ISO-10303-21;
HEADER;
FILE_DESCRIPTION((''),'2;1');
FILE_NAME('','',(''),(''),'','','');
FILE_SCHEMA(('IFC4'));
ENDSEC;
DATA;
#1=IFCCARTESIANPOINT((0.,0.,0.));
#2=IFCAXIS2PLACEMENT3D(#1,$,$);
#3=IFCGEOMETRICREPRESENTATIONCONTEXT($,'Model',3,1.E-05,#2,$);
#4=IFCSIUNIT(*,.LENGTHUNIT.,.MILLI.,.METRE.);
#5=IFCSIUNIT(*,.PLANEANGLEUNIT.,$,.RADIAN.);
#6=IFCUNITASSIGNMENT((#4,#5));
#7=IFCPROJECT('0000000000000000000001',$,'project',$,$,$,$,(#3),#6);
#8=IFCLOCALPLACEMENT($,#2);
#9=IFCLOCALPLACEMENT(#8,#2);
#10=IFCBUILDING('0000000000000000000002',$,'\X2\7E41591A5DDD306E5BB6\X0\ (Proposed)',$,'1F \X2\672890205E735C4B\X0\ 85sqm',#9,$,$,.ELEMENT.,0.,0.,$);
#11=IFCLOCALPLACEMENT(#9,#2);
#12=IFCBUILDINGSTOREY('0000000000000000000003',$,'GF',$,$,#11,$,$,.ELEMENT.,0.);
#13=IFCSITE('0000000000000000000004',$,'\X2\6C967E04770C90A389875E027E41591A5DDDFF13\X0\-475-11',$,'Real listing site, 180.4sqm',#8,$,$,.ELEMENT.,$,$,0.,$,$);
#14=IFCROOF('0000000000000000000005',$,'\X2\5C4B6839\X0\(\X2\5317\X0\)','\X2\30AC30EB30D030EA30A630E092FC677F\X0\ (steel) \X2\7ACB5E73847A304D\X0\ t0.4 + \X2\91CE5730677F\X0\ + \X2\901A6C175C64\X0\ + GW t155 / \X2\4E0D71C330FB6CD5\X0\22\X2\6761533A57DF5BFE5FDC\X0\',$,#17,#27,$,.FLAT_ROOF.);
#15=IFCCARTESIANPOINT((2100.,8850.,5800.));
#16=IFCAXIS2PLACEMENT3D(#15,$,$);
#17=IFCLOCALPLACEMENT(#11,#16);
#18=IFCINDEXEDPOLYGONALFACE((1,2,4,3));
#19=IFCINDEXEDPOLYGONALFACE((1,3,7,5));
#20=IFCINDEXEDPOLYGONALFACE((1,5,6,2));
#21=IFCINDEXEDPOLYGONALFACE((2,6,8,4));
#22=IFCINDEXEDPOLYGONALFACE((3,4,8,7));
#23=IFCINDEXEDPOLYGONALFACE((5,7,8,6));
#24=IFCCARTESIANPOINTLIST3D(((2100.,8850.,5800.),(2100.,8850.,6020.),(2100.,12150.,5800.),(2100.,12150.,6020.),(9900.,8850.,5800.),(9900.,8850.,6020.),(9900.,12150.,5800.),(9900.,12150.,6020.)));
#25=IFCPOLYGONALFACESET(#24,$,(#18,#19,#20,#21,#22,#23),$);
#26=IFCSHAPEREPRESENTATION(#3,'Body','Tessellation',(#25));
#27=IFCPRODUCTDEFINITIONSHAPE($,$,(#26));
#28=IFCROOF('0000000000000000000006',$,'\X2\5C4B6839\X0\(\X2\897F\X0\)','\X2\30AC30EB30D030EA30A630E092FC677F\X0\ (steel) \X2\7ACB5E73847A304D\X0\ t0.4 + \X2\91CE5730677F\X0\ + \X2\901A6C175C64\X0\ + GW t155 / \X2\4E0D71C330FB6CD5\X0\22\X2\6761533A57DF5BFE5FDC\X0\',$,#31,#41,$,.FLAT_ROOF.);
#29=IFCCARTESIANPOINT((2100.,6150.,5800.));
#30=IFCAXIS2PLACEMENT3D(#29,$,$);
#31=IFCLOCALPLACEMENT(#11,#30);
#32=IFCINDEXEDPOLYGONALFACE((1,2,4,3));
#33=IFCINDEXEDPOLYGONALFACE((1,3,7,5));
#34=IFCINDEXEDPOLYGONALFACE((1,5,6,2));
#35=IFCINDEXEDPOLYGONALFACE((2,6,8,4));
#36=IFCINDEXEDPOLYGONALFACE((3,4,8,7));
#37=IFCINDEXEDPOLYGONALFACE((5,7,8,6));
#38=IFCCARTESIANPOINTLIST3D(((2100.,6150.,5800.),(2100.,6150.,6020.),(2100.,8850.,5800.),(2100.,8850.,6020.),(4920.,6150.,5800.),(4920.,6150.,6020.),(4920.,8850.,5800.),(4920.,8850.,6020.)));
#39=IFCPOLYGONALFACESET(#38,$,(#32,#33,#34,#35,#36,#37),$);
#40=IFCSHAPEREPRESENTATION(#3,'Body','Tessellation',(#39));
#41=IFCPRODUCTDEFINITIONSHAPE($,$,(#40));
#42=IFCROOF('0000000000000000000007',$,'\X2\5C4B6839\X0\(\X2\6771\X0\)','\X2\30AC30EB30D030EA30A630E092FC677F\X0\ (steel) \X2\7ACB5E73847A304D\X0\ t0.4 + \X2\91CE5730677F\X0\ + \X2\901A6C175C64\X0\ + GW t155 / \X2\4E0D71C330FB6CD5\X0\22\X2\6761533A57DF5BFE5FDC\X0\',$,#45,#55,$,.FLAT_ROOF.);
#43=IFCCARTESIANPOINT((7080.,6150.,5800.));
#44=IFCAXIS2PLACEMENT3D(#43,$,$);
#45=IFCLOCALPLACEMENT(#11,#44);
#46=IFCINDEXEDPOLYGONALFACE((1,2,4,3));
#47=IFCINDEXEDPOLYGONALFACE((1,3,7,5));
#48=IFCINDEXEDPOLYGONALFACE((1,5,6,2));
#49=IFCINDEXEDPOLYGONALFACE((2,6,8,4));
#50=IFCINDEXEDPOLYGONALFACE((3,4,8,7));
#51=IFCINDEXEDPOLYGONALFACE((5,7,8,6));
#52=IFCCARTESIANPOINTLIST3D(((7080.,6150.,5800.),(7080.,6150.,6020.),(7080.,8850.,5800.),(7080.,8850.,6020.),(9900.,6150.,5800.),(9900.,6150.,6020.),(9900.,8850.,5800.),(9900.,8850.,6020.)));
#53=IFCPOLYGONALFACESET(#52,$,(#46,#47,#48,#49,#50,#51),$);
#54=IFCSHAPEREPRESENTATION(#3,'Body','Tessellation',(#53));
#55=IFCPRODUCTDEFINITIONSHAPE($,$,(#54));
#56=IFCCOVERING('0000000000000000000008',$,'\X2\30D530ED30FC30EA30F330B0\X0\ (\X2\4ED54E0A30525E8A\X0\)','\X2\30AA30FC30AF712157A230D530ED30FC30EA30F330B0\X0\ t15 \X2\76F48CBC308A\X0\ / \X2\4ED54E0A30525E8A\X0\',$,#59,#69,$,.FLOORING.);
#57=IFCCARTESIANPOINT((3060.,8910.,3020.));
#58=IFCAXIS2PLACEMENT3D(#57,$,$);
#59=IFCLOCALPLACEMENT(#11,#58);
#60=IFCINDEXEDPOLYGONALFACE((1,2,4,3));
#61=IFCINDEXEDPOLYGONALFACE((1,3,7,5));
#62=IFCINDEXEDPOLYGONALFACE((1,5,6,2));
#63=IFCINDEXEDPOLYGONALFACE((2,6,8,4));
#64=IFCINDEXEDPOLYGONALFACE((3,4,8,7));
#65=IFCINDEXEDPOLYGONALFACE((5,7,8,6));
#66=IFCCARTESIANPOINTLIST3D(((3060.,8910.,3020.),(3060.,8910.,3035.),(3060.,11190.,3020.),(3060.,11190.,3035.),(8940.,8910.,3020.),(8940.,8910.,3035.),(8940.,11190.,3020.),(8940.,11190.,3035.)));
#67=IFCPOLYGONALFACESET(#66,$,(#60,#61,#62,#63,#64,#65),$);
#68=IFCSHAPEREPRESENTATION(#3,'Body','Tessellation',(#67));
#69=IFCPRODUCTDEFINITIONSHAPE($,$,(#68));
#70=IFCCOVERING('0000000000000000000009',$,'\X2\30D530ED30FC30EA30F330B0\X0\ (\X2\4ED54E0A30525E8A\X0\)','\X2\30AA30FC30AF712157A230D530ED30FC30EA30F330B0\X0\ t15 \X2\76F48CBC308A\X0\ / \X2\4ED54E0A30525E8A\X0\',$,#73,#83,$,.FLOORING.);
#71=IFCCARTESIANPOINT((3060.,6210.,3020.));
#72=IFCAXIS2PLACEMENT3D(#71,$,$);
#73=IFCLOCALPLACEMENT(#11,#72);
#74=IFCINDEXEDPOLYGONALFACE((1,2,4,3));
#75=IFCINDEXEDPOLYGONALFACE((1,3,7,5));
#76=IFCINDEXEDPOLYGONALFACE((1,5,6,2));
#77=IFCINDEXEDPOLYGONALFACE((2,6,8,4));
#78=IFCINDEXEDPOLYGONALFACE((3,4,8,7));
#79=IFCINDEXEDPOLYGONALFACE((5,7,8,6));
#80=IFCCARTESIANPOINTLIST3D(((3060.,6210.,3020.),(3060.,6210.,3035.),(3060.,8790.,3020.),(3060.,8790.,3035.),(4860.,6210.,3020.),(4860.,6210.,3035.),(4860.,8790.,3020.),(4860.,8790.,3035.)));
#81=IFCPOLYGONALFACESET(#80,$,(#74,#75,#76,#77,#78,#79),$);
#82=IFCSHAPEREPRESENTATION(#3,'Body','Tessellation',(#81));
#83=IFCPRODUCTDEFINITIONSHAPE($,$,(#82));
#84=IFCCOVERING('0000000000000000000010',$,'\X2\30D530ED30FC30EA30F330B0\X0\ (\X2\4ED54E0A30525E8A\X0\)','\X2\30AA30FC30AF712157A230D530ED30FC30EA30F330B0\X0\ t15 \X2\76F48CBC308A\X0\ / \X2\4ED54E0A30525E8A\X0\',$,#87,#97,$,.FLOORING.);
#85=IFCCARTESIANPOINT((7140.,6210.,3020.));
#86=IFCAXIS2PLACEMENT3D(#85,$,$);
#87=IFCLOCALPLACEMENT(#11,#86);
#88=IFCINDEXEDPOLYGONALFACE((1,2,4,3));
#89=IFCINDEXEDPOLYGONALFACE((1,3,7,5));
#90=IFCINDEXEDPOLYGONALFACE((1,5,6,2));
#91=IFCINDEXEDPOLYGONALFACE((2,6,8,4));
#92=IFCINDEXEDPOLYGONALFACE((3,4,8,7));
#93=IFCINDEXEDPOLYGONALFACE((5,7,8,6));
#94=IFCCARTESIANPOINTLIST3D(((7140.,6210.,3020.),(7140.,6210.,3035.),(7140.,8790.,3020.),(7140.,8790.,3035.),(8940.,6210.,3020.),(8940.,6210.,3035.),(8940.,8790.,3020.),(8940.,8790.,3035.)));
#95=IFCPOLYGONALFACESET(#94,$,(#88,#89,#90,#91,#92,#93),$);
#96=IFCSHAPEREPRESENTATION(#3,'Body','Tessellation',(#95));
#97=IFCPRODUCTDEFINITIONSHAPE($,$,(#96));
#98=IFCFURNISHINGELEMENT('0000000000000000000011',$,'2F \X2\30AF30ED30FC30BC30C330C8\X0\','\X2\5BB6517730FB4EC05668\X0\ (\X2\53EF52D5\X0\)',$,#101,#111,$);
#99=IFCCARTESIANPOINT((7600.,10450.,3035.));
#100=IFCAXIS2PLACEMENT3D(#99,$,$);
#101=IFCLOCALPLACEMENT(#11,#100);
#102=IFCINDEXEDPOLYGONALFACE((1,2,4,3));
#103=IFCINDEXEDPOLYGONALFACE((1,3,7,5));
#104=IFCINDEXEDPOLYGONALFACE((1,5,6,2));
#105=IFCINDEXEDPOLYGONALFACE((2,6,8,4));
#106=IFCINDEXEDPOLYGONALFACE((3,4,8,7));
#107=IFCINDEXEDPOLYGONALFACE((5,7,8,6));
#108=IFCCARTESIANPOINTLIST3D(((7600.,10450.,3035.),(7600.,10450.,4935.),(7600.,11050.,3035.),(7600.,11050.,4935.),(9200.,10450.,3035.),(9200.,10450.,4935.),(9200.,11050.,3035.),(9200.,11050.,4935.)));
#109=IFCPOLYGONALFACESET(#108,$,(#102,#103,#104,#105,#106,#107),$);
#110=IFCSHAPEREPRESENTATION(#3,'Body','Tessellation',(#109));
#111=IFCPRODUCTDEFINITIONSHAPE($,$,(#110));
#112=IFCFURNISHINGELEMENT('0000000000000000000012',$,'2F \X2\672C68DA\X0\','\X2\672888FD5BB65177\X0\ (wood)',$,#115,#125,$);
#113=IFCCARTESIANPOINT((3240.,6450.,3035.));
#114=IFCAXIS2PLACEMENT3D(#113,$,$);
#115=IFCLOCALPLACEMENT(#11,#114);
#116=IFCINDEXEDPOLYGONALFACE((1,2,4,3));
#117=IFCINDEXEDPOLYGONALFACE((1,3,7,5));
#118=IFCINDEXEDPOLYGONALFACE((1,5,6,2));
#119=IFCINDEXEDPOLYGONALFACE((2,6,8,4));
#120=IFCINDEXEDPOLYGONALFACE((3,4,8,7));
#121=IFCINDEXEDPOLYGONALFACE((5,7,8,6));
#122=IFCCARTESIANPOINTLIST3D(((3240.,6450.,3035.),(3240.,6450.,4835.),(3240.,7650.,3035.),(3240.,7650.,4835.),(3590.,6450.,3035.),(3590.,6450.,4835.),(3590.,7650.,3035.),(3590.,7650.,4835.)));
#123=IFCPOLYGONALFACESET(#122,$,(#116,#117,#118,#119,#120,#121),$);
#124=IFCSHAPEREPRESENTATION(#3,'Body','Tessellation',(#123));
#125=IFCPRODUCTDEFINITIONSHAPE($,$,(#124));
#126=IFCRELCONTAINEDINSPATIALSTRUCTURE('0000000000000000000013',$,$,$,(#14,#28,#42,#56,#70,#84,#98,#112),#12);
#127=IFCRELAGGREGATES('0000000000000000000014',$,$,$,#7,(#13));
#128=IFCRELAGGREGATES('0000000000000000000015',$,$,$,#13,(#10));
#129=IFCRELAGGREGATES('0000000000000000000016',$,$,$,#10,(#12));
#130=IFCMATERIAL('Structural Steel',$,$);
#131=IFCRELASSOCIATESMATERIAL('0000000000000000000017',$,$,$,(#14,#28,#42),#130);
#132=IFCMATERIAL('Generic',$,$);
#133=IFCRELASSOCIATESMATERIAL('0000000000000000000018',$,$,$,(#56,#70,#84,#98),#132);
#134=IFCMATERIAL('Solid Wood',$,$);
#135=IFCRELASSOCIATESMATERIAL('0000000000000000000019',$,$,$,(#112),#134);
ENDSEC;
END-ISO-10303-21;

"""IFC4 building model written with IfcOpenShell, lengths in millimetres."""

from ifc_helpers import new_model, si_unit, frame, frame_2d, origin, place, context, project, spatial, rectangle, extrude, material, element, save


model = new_model("IFC4")

# Units and contexts
model_context = context("Model", 3, precision=1e-05, world=origin())
ifc_project = project(units=[si_unit("LENGTHUNIT", "METRE", prefix="MILLI"), si_unit("PLANEANGLEUNIT", "RADIAN")], contexts=[model_context])

# Site, building, storey
site_placement = place(None, origin())
site = spatial("IfcSite", under=ifc_project, at=site_placement, Name="沖縄県那覇市繁多川３-475-11", ObjectType="Real listing site, 180.4sqm", CompositionType="ELEMENT", RefElevation=0.0)
building_placement = place(site_placement, origin())
building = spatial("IfcBuilding", under=site, at=building_placement, Name="繁多川の家 (Proposed)", ObjectType="1F 木造平屋 85sqm", CompositionType="ELEMENT", ElevationOfRefHeight=0.0, ElevationOfTerrain=0.0)
storey_placement = place(building_placement, origin())
storey = spatial("IfcBuildingStorey", under=building, at=storey_placement, Name="GF", CompositionType="ELEMENT", Elevation=0.0)

# Shared definitions
ifc_material_1 = material(Name="Solid Wood")

# Shared definitions
ifc_material_2 = material(Name="Generic")

# Roofs
ifc_material_3 = material(Name="Structural Steel")
for number, where, name in (
    (1, (2100.0, 8850.0, 5800.0), "屋根(北)"),
):
    element("IfcRoof", number, at=place(storey_placement, frame(where)), inside=storey, material=ifc_material_3, Name=name, Description="ガルバリウム鋼板 (steel) 立平葺き t0.4 + 野地板 + 通気層 + GW t155 / 不燃・法22条区域対応", PredefinedType="FLAT_ROOF", context=model_context, shape_type="SweptSolid", body=[
        extrude(rectangle(XDim=7800.0, YDim=3300.0, at=frame_2d((3900.0, 1650.0))), frame((2100.0, 8850.0, 5800.0)), (0.0, 0.0, 1.0), 220.0),
    ])
roof_1_placement = place(storey_placement, frame((2100.0, 6150.0, 5800.0)))
element("IfcRoof", 2, at=roof_1_placement, inside=storey, material=ifc_material_3, Name="屋根(西)", Description="ガルバリウム鋼板 (steel) 立平葺き t0.4 + 野地板 + 通気層 + GW t155 / 不燃・法22条区域対応", PredefinedType="FLAT_ROOF", context=model_context, shape_type="SweptSolid", body=[
    extrude(rectangle(XDim=2820.0, YDim=2700.0, at=frame_2d((1410.0, 1350.0))), frame((2100.0, 6150.0, 5800.0)), (0.0, 0.0, 1.0), 220.0),
])
roof_2_placement = place(storey_placement, frame((7080.0, 6150.0, 5800.0)))
element("IfcRoof", 3, at=roof_2_placement, inside=storey, material=ifc_material_3, Name="屋根(東)", Description="ガルバリウム鋼板 (steel) 立平葺き t0.4 + 野地板 + 通気層 + GW t155 / 不燃・法22条区域対応", PredefinedType="FLAT_ROOF", context=model_context, shape_type="SweptSolid", body=[
    extrude(rectangle(XDim=2820.0, YDim=2700.0, at=frame_2d((1410.0, 1350.0))), frame((7080.0, 6150.0, 5800.0)), (0.0, 0.0, 1.0), 220.0),
])

# Coverings
covering_1_placement = place(storey_placement, frame((3060.0, 8910.0, 3020.0)))
element("IfcCovering", 4, at=covering_1_placement, inside=storey, material=ifc_material_2, Name="フローリング (仕上げ床)", Description="オーク無垢フローリング t15 直貼り / 仕上げ床", PredefinedType="FLOORING", context=model_context, shape_type="SweptSolid", body=[
    extrude(rectangle(XDim=5880.0, YDim=2280.0, at=frame_2d((2940.0, 1140.0))), frame((3060.0, 8910.0, 3020.0)), (0.0, 0.0, 1.0), 15.0),
])
covering_2_placement = place(storey_placement, frame((3060.0, 6210.0, 3020.0)))
element("IfcCovering", 5, at=covering_2_placement, inside=storey, material=ifc_material_2, Name="フローリング (仕上げ床)", Description="オーク無垢フローリング t15 直貼り / 仕上げ床", PredefinedType="FLOORING", context=model_context, shape_type="SweptSolid", body=[
    extrude(rectangle(XDim=1800.0, YDim=2580.0, at=frame_2d((900.0, 1290.0))), frame((3060.0, 6210.0, 3020.0)), (0.0, 0.0, 1.0), 15.0),
])
covering_3_placement = place(storey_placement, frame((7140.0, 6210.0, 3020.0)))
element("IfcCovering", 6, at=covering_3_placement, inside=storey, material=ifc_material_2, Name="フローリング (仕上げ床)", Description="オーク無垢フローリング t15 直貼り / 仕上げ床", PredefinedType="FLOORING", context=model_context, shape_type="SweptSolid", body=[
    extrude(rectangle(XDim=1800.0, YDim=2580.0, at=frame_2d((900.0, 1290.0))), frame((7140.0, 6210.0, 3020.0)), (0.0, 0.0, 1.0), 15.0),
])

# Furnishing elements
furnishing_1_placement = place(storey_placement, frame((7600.0, 10450.0, 3035.0)))
element("IfcFurnishingElement", 7, at=furnishing_1_placement, inside=storey, material=ifc_material_2, Name="2F クローゼット", Description="家具・什器 (可動)", context=model_context, shape_type="SweptSolid", body=[
    extrude(rectangle(XDim=1600.0, YDim=600.0, at=frame_2d((800.0, 300.0))), frame((7600.0, 10450.0, 3035.0)), (0.0, 0.0, 1.0), 1900.0),
])
furnishing_2_placement = place(storey_placement, frame((3240.0, 6450.0, 3035.0)))
element("IfcFurnishingElement", 8, at=furnishing_2_placement, inside=storey, material=ifc_material_1, Name="2F 本棚", Description="木製家具 (wood)", context=model_context, shape_type="SweptSolid", body=[
    extrude(rectangle(XDim=350.0, YDim=1200.0, at=frame_2d((175.0, 600.0))), frame((3240.0, 6450.0, 3035.0)), (0.0, 0.0, 1.0), 1800.0),
])

save(model, "model.ifc")
